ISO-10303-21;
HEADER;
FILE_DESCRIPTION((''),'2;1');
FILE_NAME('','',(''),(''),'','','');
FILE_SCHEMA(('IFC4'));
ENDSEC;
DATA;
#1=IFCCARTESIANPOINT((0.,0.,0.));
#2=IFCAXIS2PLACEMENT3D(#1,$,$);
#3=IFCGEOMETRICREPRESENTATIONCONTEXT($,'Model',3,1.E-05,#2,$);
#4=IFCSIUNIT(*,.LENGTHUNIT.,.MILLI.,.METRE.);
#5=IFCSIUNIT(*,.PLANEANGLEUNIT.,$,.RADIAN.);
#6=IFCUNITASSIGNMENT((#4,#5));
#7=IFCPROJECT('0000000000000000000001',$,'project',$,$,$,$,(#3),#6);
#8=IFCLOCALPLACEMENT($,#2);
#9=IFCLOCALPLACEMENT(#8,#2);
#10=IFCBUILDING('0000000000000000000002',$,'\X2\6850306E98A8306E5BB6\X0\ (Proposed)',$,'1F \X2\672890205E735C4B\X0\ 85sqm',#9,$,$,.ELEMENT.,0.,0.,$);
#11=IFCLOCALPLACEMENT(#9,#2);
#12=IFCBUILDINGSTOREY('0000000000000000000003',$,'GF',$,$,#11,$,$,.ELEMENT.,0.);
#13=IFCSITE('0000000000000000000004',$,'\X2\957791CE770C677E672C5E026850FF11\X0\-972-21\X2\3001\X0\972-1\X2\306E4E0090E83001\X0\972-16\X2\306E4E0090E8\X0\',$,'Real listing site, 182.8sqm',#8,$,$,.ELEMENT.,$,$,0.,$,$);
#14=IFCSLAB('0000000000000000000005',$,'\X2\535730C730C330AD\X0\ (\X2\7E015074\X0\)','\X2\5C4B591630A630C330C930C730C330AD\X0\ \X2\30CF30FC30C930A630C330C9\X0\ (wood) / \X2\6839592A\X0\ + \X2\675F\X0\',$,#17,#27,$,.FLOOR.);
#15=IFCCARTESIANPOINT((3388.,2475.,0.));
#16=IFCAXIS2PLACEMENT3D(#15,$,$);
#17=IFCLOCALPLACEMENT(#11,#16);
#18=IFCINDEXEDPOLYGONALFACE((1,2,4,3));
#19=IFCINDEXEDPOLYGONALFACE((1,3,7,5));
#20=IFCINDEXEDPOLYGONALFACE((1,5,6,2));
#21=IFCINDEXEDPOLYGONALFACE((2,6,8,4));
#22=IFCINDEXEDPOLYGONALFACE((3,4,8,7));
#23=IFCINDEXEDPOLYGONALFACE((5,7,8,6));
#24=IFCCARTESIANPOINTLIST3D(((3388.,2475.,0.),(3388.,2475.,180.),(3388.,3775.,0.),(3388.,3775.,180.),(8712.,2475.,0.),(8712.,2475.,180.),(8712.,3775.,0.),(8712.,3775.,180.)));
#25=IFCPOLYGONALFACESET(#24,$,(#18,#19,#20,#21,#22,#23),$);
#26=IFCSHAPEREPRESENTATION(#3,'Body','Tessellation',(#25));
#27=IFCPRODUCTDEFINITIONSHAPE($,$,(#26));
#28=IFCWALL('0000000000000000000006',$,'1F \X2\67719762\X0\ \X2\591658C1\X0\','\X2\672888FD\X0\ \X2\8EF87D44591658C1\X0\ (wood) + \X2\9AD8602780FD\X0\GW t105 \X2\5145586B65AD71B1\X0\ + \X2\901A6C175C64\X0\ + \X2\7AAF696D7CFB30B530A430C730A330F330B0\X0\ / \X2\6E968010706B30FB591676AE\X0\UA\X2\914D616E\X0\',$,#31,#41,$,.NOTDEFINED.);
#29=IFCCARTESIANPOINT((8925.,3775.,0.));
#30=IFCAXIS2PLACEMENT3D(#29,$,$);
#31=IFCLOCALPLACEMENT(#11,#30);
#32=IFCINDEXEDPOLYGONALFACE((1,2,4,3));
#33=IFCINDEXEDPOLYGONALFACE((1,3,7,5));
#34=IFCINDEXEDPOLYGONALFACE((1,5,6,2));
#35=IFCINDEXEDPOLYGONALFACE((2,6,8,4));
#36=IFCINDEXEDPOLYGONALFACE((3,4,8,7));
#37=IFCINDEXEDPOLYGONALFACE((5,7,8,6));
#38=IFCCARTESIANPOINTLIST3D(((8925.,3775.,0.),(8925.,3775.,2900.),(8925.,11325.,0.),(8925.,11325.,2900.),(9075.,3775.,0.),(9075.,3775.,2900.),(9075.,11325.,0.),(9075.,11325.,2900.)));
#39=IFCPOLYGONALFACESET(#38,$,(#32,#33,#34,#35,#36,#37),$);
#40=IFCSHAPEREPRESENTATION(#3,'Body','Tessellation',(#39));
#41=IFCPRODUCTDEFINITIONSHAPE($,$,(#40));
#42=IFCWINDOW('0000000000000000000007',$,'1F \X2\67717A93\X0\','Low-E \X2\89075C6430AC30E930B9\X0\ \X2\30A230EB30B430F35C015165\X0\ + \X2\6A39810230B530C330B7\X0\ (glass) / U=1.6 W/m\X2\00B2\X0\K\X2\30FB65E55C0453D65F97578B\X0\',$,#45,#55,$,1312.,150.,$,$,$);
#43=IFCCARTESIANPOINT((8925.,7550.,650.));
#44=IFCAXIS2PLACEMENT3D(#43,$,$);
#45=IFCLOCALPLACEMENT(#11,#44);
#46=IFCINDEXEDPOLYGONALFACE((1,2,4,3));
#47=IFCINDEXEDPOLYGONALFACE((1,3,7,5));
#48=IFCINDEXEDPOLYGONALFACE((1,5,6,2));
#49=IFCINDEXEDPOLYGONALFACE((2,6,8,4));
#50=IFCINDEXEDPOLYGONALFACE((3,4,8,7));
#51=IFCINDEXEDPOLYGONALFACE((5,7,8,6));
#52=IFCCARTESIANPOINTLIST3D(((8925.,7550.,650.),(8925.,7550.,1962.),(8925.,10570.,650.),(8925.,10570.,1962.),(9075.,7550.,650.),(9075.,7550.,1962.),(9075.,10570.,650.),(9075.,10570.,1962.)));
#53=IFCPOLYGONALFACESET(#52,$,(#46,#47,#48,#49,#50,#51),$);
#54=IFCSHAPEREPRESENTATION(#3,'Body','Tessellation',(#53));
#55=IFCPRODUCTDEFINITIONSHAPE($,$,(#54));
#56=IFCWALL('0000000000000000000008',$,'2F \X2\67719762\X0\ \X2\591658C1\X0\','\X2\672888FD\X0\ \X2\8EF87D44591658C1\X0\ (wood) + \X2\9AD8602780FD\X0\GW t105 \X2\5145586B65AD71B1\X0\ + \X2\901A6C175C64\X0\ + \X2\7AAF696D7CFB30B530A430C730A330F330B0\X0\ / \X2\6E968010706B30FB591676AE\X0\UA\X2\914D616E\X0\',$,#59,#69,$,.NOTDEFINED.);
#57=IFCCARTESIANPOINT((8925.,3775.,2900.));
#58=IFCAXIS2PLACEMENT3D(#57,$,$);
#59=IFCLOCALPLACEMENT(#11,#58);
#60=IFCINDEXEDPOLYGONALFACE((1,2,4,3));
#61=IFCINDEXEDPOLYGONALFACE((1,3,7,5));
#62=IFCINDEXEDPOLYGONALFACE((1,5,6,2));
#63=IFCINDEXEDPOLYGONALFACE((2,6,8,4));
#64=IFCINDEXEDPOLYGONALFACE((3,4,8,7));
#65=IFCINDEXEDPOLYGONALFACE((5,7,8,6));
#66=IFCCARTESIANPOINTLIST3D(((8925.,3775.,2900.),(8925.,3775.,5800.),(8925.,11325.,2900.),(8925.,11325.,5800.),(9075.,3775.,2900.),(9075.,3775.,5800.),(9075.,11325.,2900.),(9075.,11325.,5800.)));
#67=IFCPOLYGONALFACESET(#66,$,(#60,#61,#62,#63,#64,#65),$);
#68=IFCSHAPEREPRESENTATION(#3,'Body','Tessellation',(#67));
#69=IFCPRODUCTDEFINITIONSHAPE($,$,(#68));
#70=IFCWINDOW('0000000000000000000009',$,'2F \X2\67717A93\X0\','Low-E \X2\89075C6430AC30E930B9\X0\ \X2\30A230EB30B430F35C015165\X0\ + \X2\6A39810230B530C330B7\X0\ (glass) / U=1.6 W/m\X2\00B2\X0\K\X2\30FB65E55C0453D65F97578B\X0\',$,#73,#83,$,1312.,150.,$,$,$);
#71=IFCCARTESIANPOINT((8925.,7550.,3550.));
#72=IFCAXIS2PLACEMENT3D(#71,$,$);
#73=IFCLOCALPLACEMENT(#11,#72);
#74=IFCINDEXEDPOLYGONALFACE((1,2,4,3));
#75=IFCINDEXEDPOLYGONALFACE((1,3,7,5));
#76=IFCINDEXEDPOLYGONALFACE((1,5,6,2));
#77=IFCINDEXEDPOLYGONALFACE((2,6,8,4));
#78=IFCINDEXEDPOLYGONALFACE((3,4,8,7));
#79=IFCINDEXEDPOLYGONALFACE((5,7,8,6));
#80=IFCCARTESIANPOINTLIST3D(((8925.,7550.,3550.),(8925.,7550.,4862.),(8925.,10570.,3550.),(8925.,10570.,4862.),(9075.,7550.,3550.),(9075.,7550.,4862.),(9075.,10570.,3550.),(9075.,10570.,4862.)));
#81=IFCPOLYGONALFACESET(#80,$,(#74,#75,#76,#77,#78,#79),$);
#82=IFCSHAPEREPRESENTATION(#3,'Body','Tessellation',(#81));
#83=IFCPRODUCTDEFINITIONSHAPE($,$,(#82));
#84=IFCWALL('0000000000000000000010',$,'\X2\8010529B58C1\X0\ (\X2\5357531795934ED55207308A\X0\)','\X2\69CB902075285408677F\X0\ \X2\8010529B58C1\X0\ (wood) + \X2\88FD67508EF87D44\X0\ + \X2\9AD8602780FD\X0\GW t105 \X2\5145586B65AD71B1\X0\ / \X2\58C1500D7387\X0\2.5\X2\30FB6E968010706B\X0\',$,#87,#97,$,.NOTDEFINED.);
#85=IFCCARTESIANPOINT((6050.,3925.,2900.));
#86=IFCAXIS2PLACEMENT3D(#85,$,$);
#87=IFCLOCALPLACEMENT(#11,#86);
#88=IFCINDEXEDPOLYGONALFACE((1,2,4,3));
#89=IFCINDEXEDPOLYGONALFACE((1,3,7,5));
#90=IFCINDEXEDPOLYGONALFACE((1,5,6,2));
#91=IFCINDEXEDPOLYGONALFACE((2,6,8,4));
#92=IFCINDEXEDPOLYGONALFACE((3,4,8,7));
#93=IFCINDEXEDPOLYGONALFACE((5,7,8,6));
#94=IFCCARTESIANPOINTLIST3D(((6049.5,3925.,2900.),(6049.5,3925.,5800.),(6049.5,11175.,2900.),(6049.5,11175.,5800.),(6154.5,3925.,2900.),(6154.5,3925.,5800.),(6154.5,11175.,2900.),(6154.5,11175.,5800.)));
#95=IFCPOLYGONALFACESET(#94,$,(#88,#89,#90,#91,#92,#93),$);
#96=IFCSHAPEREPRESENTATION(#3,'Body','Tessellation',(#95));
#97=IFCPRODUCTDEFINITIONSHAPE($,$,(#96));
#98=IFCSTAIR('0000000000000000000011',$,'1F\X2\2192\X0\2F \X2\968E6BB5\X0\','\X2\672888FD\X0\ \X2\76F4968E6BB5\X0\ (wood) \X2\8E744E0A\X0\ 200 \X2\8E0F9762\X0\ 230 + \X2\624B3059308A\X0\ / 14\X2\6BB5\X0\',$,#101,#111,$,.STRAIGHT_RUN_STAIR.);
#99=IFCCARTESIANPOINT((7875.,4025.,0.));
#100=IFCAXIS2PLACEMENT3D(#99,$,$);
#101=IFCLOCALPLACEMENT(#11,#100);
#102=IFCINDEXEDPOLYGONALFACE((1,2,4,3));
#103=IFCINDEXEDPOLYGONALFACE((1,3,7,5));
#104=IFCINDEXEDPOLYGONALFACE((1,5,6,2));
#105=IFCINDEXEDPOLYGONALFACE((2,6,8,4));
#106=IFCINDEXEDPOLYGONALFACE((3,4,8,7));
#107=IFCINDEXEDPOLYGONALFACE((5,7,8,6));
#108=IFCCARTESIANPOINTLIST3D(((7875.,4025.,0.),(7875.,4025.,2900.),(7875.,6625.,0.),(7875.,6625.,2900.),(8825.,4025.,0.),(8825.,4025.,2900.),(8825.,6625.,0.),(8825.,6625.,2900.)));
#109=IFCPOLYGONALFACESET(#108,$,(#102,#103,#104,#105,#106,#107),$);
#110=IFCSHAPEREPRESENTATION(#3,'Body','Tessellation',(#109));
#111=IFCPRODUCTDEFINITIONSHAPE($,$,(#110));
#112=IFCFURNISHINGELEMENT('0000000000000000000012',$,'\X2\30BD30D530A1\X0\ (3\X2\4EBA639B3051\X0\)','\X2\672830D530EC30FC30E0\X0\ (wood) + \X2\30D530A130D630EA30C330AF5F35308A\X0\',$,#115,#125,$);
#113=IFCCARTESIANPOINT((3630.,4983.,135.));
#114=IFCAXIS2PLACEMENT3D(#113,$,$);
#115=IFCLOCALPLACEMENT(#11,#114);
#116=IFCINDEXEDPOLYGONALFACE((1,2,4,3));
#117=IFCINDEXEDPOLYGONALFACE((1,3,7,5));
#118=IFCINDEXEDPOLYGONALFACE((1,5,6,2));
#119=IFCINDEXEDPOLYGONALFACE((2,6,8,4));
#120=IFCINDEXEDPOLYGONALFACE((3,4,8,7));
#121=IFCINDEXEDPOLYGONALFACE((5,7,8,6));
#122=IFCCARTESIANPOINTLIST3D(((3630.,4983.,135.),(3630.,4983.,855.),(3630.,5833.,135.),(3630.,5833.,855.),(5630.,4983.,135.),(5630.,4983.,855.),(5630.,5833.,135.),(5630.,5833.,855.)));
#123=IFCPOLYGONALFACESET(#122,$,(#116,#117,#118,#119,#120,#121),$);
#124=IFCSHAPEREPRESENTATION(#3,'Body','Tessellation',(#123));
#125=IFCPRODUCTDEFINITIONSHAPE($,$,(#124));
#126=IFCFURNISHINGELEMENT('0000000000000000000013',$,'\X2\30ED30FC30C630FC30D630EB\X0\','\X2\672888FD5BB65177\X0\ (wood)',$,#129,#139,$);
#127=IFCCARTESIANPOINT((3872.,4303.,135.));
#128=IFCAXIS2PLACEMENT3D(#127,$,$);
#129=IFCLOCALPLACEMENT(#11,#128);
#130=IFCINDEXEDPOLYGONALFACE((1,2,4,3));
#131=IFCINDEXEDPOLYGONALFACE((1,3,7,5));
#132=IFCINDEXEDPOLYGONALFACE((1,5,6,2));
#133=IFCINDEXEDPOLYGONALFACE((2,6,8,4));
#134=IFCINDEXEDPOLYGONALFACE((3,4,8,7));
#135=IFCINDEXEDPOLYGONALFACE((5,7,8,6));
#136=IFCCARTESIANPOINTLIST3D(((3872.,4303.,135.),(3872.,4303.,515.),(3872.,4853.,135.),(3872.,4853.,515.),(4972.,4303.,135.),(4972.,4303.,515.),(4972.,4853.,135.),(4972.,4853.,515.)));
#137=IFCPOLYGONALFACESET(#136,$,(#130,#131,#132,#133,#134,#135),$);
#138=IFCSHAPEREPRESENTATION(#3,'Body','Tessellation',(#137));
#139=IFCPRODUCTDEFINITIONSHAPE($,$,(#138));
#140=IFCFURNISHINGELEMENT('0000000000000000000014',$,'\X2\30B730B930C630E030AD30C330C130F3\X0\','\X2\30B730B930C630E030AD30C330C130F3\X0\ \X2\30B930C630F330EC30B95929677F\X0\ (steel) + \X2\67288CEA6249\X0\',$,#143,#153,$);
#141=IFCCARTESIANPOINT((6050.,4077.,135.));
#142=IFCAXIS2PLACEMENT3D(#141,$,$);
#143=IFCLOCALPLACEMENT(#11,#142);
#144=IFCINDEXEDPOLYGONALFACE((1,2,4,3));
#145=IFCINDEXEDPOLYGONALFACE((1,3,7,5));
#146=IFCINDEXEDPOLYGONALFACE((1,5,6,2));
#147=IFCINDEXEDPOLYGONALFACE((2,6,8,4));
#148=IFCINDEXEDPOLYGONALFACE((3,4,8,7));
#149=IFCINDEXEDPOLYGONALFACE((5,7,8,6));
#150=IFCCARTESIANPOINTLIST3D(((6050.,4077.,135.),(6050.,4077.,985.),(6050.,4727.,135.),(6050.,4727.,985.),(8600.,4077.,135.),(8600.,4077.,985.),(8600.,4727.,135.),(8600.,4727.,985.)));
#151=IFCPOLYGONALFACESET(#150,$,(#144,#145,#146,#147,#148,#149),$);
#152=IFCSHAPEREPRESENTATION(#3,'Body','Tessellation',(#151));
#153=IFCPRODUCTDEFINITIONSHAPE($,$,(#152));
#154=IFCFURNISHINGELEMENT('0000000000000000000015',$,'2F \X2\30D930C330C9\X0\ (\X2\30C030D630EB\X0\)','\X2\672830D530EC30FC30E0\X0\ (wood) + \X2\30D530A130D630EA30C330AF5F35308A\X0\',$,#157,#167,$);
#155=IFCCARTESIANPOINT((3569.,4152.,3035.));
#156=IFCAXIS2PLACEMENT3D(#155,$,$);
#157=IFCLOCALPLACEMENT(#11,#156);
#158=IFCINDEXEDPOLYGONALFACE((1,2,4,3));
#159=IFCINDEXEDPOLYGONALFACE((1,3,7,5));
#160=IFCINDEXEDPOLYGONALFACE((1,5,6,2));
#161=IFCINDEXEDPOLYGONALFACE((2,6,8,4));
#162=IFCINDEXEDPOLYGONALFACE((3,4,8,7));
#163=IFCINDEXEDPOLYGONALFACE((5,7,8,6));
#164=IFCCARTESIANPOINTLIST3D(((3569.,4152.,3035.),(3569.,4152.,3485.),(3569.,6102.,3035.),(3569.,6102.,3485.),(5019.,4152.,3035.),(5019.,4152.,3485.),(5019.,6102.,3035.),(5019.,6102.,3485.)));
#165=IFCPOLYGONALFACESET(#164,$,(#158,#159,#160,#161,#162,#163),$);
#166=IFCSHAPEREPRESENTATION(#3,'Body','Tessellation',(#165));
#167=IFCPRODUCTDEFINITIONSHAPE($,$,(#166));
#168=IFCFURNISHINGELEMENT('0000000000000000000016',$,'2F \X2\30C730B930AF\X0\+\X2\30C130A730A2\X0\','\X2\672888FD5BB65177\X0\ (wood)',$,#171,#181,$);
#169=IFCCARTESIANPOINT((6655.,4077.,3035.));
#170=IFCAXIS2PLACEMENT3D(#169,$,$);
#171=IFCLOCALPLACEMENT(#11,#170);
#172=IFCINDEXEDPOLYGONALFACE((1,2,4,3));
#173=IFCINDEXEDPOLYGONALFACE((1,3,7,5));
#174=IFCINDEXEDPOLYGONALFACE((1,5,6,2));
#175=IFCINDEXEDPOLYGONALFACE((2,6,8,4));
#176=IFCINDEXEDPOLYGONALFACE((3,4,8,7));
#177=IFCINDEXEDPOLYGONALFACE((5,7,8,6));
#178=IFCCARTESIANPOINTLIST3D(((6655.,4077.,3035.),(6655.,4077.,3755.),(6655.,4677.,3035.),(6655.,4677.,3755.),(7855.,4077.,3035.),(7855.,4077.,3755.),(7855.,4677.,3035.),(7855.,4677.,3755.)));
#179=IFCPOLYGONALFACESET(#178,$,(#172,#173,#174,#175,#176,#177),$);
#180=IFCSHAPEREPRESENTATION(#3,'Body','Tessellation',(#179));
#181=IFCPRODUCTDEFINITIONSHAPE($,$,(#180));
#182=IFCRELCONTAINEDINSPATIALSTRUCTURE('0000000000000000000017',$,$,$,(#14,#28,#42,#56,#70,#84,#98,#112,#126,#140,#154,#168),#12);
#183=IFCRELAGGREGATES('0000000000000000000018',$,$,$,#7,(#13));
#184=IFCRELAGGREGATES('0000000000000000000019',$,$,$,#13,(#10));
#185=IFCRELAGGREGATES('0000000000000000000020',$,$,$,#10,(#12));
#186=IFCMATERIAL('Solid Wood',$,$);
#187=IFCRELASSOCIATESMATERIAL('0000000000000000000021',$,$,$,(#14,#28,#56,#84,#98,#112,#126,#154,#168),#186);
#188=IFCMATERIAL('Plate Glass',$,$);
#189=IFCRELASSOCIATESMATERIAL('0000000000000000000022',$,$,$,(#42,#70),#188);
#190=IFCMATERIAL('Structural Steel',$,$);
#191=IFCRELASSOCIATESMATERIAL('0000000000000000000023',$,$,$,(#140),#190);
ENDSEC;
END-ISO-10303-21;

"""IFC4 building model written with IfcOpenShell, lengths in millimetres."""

from ifc_helpers import new_model, si_unit, frame, frame_2d, origin, place, context, project, spatial, rectangle, extrude, material, element, fill, save


model = new_model("IFC4")

# Units and contexts
model_context = context("Model", 3, precision=1e-05, world=origin())
ifc_project = project(units=[si_unit("LENGTHUNIT", "METRE", prefix="MILLI"), si_unit("PLANEANGLEUNIT", "RADIAN")], contexts=[model_context])

# Site, building, storey
site_placement = place(None, origin())
site = spatial("IfcSite", under=ifc_project, at=site_placement, Name="長野県松本市桐１-972-21、972-1の一部、972-16の一部", ObjectType="Real listing site, 182.8sqm", CompositionType="ELEMENT", RefElevation=0.0)
building_placement = place(site_placement, origin())
building = spatial("IfcBuilding", under=site, at=building_placement, Name="桐の風の家 (Proposed)", ObjectType="1F 木造平屋 85sqm", CompositionType="ELEMENT", ElevationOfRefHeight=0.0, ElevationOfTerrain=0.0)
storey_placement = place(building_placement, origin())
storey = spatial("IfcBuildingStorey", under=building, at=storey_placement, Name="GF", CompositionType="ELEMENT", Elevation=0.0)

# Slab
ifc_material_1 = material(Name="Solid Wood")
slab_placement = place(storey_placement, frame((3388.0, 2475.0, 0.0)))
element("IfcSlab", 1, at=slab_placement, inside=storey, material=ifc_material_1, Name="南デッキ (縁側)", Description="屋外ウッドデッキ ハードウッド (wood) / 根太 + 束", PredefinedType="FLOOR", context=model_context, shape_type="SweptSolid", body=[
    extrude(rectangle(XDim=5324.0, YDim=1300.0, at=frame_2d((2662.0, 650.0))), frame((3388.0, 2475.0, 0.0)), (0.0, 0.0, 1.0), 180.0),
])

# Wall, opening, window
wall_1_placement = place(storey_placement, frame((8925.0, 3775.0, 0.0)))
wall_1 = element("IfcWall", 2, at=wall_1_placement, inside=storey, material=ifc_material_1, Name="1F 東面 外壁", Description="木製 軸組外壁 (wood) + 高性能GW t105 充填断熱 + 通気層 + 窯業系サイディング / 準耐火・外皮UA配慮", PredefinedType="NOTDEFINED", context=model_context, shape_type="SweptSolid", body=[
    extrude(rectangle(XDim=150.0, YDim=7550.0, at=frame_2d((75.0, 3775.0))), frame((8925.0, 3775.0, 0.0)), (0.0, 0.0, 1.0), 2900.0),
])
opening_1_placement = place(storey_placement, frame((8925.0, 7550.0, 650.0)))
opening_1 = element("IfcOpeningElement", 3, at=opening_1_placement, cuts=wall_1, PredefinedType="NOTDEFINED", context=model_context, shape_type="SweptSolid", body=[
    extrude(rectangle(XDim=150.0, YDim=3020.0, at=frame_2d((75.0, 1510.0))), frame((8925.0, 7550.0, 650.0)), (0.0, 0.0, 1.0), 1312.0),
])
ifc_material_2 = material(Name="Plate Glass")
window_1_placement = place(storey_placement, frame((8925.0, 7550.0, 650.0)))
window_1 = element("IfcWindow", 4, at=window_1_placement, inside=storey, material=ifc_material_2, Name="1F 東窓", Description="Low-E 複層ガラス アルゴン封入 + 樹脂サッシ (glass) / U=1.6 W/m²K・日射取得型", OverallHeight=1312.0, OverallWidth=150.0, context=model_context, shape_type="SweptSolid", body=[
    extrude(rectangle(XDim=150.0, YDim=3020.0, at=frame_2d((75.0, 1510.0))), frame((8925.0, 7550.0, 650.0)), (0.0, 0.0, 1.0), 1312.0),
])
fill(opening_1, window_1)

# Wall, opening, window
wall_2_placement = place(storey_placement, frame((8925.0, 3775.0, 2900.0)))
wall_2 = element("IfcWall", 5, at=wall_2_placement, inside=storey, material=ifc_material_1, Name="2F 東面 外壁", Description="木製 軸組外壁 (wood) + 高性能GW t105 充填断熱 + 通気層 + 窯業系サイディング / 準耐火・外皮UA配慮", PredefinedType="NOTDEFINED", context=model_context, shape_type="SweptSolid", body=[
    extrude(rectangle(XDim=150.0, YDim=7550.0, at=frame_2d((75.0, 3775.0))), frame((8925.0, 3775.0, 2900.0)), (0.0, 0.0, 1.0), 2900.0),
])
opening_2_placement = place(storey_placement, frame((8925.0, 7550.0, 3550.0)))
opening_2 = element("IfcOpeningElement", 6, at=opening_2_placement, cuts=wall_2, PredefinedType="NOTDEFINED", context=model_context, shape_type="SweptSolid", body=[
    extrude(rectangle(XDim=150.0, YDim=3020.0, at=frame_2d((75.0, 1510.0))), frame((8925.0, 7550.0, 3550.0)), (0.0, 0.0, 1.0), 1312.0),
])
window_2_placement = place(storey_placement, frame((8925.0, 7550.0, 3550.0)))
window_2 = element("IfcWindow", 7, at=window_2_placement, inside=storey, material=ifc_material_2, Name="2F 東窓", Description="Low-E 複層ガラス アルゴン封入 + 樹脂サッシ (glass) / U=1.6 W/m²K・日射取得型", OverallHeight=1312.0, OverallWidth=150.0, context=model_context, shape_type="SweptSolid", body=[
    extrude(rectangle(XDim=150.0, YDim=3020.0, at=frame_2d((75.0, 1510.0))), frame((8925.0, 7550.0, 3550.0)), (0.0, 0.0, 1.0), 1312.0),
])
fill(opening_2, window_2)

# Wall
wall_3_placement = place(storey_placement, frame((6050.0, 3925.0, 2900.0)))
element("IfcWall", 8, at=wall_3_placement, inside=storey, material=ifc_material_1, Name="耐力壁 (南北間仕切り)", Description="構造用合板 耐力壁 (wood) + 製材軸組 + 高性能GW t105 充填断熱 / 壁倍率2.5・準耐火", PredefinedType="NOTDEFINED", context=model_context, shape_type="SweptSolid", body=[
    extrude(rectangle(XDim=105.0, YDim=7250.0, at=frame_2d((52.0, 3625.0))), frame((6050.0, 3925.0, 2900.0)), (0.0, 0.0, 1.0), 2900.0),
])

# Stair
stair_placement = place(storey_placement, frame((7875.0, 4025.0, 0.0)))
element("IfcStair", 9, at=stair_placement, inside=storey, material=ifc_material_1, Name="1F→2F 階段", Description="木製 直階段 (wood) 蹴上 200 踏面 230 + 手すり / 14段", PredefinedType="STRAIGHT_RUN_STAIR", context=model_context, shape_type="SweptSolid", body=[
    extrude(rectangle(XDim=950.0, YDim=2600.0, at=frame_2d((475.0, 1300.0))), frame((7875.0, 4025.0, 0.0)), (0.0, 0.0, 1.0), 2900.0),
])

# Furnishing elements
furnishing_1_placement = place(storey_placement, frame((3630.0, 4983.0, 135.0)))
element("IfcFurnishingElement", 10, at=furnishing_1_placement, inside=storey, material=ifc_material_1, Name="ソファ (3人掛け)", Description="木フレーム (wood) + ファブリック張り", context=model_context, shape_type="SweptSolid", body=[
    extrude(rectangle(XDim=2000.0, YDim=850.0, at=frame_2d((1000.0, 425.0))), frame((3630.0, 4983.0, 135.0)), (0.0, 0.0, 1.0), 720.0),
])
furnishing_2_placement = place(storey_placement, frame((3872.0, 4303.0, 135.0)))
element("IfcFurnishingElement", 11, at=furnishing_2_placement, inside=storey, material=ifc_material_1, Name="ローテーブル", Description="木製家具 (wood)", context=model_context, shape_type="SweptSolid", body=[
    extrude(rectangle(XDim=1100.0, YDim=550.0, at=frame_2d((550.0, 275.0))), frame((3872.0, 4303.0, 135.0)), (0.0, 0.0, 1.0), 380.0),
])
ifc_material_3 = material(Name="Structural Steel")
furnishing_3_placement = place(storey_placement, frame((6050.0, 4077.0, 135.0)))
element("IfcFurnishingElement", 12, at=furnishing_3_placement, inside=storey, material=ifc_material_3, Name="システムキッチン", Description="システムキッチン ステンレス天板 (steel) + 木質扉", context=model_context, shape_type="SweptSolid", body=[
    extrude(rectangle(XDim=2550.0, YDim=650.0, at=frame_2d((1275.0, 325.0))), frame((6050.0, 4077.0, 135.0)), (0.0, 0.0, 1.0), 850.0),
])
furnishing_4_placement = place(storey_placement, frame((3569.0, 4152.0, 3035.0)))
element("IfcFurnishingElement", 13, at=furnishing_4_placement, inside=storey, material=ifc_material_1, Name="2F ベッド (ダブル)", Description="木フレーム (wood) + ファブリック張り", context=model_context, shape_type="SweptSolid", body=[
    extrude(rectangle(XDim=1450.0, YDim=1950.0, at=frame_2d((725.0, 975.0))), frame((3569.0, 4152.0, 3035.0)), (0.0, 0.0, 1.0), 450.0),
])
furnishing_5_placement = place(storey_placement, frame((6655.0, 4077.0, 3035.0)))
element("IfcFurnishingElement", 14, at=furnishing_5_placement, inside=storey, material=ifc_material_1, Name="2F デスク+チェア", Description="木製家具 (wood)", context=model_context, shape_type="SweptSolid", body=[
    extrude(rectangle(XDim=1200.0, YDim=600.0, at=frame_2d((600.0, 300.0))), frame((6655.0, 4077.0, 3035.0)), (0.0, 0.0, 1.0), 720.0),
])

save(model, "model.ifc")
